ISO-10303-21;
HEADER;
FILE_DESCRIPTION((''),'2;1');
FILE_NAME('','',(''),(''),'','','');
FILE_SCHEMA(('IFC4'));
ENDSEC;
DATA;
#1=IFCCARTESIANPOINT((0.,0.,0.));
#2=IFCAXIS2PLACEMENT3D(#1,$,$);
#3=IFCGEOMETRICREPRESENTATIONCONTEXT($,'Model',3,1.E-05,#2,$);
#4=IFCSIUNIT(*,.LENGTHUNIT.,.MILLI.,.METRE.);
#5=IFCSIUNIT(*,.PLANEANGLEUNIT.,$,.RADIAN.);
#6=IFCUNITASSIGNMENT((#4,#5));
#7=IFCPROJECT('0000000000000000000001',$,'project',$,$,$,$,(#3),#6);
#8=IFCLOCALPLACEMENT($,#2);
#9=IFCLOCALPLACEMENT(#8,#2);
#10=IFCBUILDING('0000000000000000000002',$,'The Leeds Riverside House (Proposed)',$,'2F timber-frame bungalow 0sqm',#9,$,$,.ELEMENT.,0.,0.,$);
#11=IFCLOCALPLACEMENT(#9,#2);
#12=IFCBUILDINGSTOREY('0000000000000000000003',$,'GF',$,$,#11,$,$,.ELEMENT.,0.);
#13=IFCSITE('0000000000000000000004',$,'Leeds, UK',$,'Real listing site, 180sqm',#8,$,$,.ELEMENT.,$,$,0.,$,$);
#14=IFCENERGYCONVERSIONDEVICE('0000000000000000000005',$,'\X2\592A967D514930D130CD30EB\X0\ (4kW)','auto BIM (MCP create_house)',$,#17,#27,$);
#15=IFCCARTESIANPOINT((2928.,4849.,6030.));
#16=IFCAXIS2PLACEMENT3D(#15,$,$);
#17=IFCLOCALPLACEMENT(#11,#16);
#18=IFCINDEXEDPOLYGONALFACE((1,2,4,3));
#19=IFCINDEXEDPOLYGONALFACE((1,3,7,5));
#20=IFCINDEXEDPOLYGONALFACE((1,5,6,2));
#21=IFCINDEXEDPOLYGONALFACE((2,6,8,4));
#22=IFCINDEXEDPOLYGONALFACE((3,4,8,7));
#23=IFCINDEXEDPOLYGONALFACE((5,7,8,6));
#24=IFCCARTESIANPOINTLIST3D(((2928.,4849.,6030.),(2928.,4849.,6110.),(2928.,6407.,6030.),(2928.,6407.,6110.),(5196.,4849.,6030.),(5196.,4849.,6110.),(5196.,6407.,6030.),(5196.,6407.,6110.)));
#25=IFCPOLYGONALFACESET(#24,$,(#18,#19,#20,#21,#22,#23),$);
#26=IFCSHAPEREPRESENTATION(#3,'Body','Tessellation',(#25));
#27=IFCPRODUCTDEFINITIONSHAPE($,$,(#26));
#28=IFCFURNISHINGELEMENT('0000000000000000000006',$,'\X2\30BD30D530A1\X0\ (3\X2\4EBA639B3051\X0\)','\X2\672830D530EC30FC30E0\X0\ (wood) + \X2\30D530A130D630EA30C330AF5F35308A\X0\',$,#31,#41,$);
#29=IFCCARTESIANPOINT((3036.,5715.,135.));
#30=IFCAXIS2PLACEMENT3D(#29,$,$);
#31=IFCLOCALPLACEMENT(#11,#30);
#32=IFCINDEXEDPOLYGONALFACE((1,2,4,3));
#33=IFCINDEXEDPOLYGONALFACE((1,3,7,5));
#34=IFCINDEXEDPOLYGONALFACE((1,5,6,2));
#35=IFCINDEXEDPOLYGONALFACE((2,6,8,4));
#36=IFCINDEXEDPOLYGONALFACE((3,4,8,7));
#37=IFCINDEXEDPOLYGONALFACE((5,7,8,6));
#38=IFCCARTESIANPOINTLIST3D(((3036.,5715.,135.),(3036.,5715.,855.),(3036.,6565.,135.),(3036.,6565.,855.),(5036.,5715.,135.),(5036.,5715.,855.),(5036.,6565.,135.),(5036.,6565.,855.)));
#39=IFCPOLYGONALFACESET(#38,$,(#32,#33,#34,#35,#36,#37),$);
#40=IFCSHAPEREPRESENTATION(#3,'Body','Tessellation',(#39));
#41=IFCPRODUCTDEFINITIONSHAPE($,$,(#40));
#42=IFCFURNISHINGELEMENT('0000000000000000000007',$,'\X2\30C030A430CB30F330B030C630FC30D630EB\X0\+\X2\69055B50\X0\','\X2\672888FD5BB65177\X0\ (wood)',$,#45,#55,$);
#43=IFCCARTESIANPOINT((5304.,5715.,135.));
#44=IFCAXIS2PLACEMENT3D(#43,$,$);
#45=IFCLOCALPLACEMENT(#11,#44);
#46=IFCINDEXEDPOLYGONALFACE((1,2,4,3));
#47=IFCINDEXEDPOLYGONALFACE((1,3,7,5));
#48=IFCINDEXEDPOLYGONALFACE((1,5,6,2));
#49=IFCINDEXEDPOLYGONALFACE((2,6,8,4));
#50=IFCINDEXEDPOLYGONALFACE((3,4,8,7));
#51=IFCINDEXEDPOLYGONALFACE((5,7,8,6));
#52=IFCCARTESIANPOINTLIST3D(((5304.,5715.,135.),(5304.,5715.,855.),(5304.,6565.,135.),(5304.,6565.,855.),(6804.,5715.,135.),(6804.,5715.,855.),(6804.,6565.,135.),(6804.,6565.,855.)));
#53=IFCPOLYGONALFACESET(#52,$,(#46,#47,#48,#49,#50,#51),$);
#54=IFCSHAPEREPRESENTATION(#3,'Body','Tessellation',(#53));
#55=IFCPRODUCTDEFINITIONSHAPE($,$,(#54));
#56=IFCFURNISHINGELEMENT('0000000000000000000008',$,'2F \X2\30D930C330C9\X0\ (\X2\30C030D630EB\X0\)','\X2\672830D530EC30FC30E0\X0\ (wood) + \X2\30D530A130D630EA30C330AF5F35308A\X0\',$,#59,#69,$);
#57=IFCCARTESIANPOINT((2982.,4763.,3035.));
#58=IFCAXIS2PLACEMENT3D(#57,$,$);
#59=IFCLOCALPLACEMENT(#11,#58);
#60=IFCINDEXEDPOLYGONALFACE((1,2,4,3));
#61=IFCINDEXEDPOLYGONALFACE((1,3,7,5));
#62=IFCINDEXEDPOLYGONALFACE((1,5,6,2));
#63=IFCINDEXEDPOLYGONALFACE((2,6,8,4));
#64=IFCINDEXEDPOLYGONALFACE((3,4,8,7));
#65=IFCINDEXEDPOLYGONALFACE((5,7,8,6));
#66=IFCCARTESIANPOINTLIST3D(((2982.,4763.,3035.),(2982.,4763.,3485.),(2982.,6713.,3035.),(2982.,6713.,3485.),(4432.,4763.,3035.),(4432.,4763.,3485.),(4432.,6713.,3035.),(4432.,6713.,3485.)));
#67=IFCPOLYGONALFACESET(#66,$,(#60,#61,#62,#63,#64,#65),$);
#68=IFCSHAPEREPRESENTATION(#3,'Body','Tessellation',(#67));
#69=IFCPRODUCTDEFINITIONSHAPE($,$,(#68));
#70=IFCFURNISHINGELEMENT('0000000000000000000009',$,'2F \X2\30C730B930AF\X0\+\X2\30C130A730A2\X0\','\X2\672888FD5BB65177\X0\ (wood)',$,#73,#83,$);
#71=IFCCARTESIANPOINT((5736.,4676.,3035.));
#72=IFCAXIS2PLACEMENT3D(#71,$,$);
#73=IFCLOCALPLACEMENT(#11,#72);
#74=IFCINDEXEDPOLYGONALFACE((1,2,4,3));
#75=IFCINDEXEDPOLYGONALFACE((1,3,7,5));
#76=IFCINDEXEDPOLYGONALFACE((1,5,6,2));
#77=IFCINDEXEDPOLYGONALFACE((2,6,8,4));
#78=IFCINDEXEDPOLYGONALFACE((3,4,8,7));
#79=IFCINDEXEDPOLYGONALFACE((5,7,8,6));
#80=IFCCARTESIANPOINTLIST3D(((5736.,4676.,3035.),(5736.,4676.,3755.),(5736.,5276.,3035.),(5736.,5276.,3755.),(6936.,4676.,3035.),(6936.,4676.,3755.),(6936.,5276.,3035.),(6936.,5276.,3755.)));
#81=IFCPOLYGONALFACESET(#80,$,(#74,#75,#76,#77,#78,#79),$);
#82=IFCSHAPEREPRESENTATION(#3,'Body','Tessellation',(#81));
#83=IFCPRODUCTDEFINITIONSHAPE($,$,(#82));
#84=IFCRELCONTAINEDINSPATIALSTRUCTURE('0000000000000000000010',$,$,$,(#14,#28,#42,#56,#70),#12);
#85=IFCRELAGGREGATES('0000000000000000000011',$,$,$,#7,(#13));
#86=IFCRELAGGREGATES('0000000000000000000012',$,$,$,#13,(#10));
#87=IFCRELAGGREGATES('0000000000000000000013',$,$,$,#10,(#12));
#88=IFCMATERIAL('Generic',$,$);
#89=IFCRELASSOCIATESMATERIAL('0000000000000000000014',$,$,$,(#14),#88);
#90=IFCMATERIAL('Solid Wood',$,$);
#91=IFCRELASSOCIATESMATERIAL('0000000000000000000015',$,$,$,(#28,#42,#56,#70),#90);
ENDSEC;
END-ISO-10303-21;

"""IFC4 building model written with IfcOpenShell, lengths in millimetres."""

from ifc_helpers import new_model, si_unit, frame, frame_2d, origin, place, context, project, spatial, rectangle, extrude, material, element, save


model = new_model("IFC4")

# Units and contexts
model_context = context("Model", 3, precision=1e-05, world=origin())
ifc_project = project(units=[si_unit("LENGTHUNIT", "METRE", prefix="MILLI"), si_unit("PLANEANGLEUNIT", "RADIAN")], contexts=[model_context])

# Site, building, storey
site_placement = place(None, origin())
site = spatial("IfcSite", under=ifc_project, at=site_placement, Name="Leeds, UK", ObjectType="Real listing site, 180sqm", CompositionType="ELEMENT", RefElevation=0.0)
building_placement = place(site_placement, origin())
building = spatial("IfcBuilding", under=site, at=building_placement, Name="The Leeds Riverside House (Proposed)", ObjectType="2F timber-frame bungalow 0sqm", CompositionType="ELEMENT", ElevationOfRefHeight=0.0, ElevationOfTerrain=0.0)
storey_placement = place(building_placement, origin())
storey = spatial("IfcBuildingStorey", under=building, at=storey_placement, Name="GF", CompositionType="ELEMENT", Elevation=0.0)

# Shared definitions
ifc_material_1 = material(Name="Solid Wood")

# Shared definitions
ifc_material_2 = material(Name="Generic")

# Energy conversion device
energy_conversion_device_placement = place(storey_placement, frame((2928.0, 4849.0, 6030.0)))
element("IfcEnergyConversionDevice", 1, at=energy_conversion_device_placement, inside=storey, material=ifc_material_2, Name="太陽光パネル (4kW)", Description="auto BIM (MCP create_house)", context=model_context, shape_type="SweptSolid", body=[
    extrude(rectangle(XDim=2268.0, YDim=1558.0, at=frame_2d((1134.0, 779.0))), frame((2928.0, 4849.0, 6030.0)), (0.0, 0.0, 1.0), 80.0),
])

# Furnishing elements
furnishing_1_placement = place(storey_placement, frame((3036.0, 5715.0, 135.0)))
element("IfcFurnishingElement", 2, at=furnishing_1_placement, inside=storey, material=ifc_material_1, Name="ソファ (3人掛け)", Description="木フレーム (wood) + ファブリック張り", context=model_context, shape_type="SweptSolid", body=[
    extrude(rectangle(XDim=2000.0, YDim=850.0, at=frame_2d((1000.0, 425.0))), frame((3036.0, 5715.0, 135.0)), (0.0, 0.0, 1.0), 720.0),
])
furnishing_2_placement = place(storey_placement, frame((5304.0, 5715.0, 135.0)))
element("IfcFurnishingElement", 3, at=furnishing_2_placement, inside=storey, material=ifc_material_1, Name="ダイニングテーブル+椅子", Description="木製家具 (wood)", context=model_context, shape_type="SweptSolid", body=[
    extrude(rectangle(XDim=1500.0, YDim=850.0, at=frame_2d((750.0, 425.0))), frame((5304.0, 5715.0, 135.0)), (0.0, 0.0, 1.0), 720.0),
])
furnishing_3_placement = place(storey_placement, frame((2982.0, 4763.0, 3035.0)))
element("IfcFurnishingElement", 4, at=furnishing_3_placement, inside=storey, material=ifc_material_1, Name="2F ベッド (ダブル)", Description="木フレーム (wood) + ファブリック張り", context=model_context, shape_type="SweptSolid", body=[
    extrude(rectangle(XDim=1450.0, YDim=1950.0, at=frame_2d((725.0, 975.0))), frame((2982.0, 4763.0, 3035.0)), (0.0, 0.0, 1.0), 450.0),
])
furnishing_4_placement = place(storey_placement, frame((5736.0, 4676.0, 3035.0)))
element("IfcFurnishingElement", 5, at=furnishing_4_placement, inside=storey, material=ifc_material_1, Name="2F デスク+チェア", Description="木製家具 (wood)", context=model_context, shape_type="SweptSolid", body=[
    extrude(rectangle(XDim=1200.0, YDim=600.0, at=frame_2d((600.0, 300.0))), frame((5736.0, 4676.0, 3035.0)), (0.0, 0.0, 1.0), 720.0),
])

save(model, "model.ifc")
